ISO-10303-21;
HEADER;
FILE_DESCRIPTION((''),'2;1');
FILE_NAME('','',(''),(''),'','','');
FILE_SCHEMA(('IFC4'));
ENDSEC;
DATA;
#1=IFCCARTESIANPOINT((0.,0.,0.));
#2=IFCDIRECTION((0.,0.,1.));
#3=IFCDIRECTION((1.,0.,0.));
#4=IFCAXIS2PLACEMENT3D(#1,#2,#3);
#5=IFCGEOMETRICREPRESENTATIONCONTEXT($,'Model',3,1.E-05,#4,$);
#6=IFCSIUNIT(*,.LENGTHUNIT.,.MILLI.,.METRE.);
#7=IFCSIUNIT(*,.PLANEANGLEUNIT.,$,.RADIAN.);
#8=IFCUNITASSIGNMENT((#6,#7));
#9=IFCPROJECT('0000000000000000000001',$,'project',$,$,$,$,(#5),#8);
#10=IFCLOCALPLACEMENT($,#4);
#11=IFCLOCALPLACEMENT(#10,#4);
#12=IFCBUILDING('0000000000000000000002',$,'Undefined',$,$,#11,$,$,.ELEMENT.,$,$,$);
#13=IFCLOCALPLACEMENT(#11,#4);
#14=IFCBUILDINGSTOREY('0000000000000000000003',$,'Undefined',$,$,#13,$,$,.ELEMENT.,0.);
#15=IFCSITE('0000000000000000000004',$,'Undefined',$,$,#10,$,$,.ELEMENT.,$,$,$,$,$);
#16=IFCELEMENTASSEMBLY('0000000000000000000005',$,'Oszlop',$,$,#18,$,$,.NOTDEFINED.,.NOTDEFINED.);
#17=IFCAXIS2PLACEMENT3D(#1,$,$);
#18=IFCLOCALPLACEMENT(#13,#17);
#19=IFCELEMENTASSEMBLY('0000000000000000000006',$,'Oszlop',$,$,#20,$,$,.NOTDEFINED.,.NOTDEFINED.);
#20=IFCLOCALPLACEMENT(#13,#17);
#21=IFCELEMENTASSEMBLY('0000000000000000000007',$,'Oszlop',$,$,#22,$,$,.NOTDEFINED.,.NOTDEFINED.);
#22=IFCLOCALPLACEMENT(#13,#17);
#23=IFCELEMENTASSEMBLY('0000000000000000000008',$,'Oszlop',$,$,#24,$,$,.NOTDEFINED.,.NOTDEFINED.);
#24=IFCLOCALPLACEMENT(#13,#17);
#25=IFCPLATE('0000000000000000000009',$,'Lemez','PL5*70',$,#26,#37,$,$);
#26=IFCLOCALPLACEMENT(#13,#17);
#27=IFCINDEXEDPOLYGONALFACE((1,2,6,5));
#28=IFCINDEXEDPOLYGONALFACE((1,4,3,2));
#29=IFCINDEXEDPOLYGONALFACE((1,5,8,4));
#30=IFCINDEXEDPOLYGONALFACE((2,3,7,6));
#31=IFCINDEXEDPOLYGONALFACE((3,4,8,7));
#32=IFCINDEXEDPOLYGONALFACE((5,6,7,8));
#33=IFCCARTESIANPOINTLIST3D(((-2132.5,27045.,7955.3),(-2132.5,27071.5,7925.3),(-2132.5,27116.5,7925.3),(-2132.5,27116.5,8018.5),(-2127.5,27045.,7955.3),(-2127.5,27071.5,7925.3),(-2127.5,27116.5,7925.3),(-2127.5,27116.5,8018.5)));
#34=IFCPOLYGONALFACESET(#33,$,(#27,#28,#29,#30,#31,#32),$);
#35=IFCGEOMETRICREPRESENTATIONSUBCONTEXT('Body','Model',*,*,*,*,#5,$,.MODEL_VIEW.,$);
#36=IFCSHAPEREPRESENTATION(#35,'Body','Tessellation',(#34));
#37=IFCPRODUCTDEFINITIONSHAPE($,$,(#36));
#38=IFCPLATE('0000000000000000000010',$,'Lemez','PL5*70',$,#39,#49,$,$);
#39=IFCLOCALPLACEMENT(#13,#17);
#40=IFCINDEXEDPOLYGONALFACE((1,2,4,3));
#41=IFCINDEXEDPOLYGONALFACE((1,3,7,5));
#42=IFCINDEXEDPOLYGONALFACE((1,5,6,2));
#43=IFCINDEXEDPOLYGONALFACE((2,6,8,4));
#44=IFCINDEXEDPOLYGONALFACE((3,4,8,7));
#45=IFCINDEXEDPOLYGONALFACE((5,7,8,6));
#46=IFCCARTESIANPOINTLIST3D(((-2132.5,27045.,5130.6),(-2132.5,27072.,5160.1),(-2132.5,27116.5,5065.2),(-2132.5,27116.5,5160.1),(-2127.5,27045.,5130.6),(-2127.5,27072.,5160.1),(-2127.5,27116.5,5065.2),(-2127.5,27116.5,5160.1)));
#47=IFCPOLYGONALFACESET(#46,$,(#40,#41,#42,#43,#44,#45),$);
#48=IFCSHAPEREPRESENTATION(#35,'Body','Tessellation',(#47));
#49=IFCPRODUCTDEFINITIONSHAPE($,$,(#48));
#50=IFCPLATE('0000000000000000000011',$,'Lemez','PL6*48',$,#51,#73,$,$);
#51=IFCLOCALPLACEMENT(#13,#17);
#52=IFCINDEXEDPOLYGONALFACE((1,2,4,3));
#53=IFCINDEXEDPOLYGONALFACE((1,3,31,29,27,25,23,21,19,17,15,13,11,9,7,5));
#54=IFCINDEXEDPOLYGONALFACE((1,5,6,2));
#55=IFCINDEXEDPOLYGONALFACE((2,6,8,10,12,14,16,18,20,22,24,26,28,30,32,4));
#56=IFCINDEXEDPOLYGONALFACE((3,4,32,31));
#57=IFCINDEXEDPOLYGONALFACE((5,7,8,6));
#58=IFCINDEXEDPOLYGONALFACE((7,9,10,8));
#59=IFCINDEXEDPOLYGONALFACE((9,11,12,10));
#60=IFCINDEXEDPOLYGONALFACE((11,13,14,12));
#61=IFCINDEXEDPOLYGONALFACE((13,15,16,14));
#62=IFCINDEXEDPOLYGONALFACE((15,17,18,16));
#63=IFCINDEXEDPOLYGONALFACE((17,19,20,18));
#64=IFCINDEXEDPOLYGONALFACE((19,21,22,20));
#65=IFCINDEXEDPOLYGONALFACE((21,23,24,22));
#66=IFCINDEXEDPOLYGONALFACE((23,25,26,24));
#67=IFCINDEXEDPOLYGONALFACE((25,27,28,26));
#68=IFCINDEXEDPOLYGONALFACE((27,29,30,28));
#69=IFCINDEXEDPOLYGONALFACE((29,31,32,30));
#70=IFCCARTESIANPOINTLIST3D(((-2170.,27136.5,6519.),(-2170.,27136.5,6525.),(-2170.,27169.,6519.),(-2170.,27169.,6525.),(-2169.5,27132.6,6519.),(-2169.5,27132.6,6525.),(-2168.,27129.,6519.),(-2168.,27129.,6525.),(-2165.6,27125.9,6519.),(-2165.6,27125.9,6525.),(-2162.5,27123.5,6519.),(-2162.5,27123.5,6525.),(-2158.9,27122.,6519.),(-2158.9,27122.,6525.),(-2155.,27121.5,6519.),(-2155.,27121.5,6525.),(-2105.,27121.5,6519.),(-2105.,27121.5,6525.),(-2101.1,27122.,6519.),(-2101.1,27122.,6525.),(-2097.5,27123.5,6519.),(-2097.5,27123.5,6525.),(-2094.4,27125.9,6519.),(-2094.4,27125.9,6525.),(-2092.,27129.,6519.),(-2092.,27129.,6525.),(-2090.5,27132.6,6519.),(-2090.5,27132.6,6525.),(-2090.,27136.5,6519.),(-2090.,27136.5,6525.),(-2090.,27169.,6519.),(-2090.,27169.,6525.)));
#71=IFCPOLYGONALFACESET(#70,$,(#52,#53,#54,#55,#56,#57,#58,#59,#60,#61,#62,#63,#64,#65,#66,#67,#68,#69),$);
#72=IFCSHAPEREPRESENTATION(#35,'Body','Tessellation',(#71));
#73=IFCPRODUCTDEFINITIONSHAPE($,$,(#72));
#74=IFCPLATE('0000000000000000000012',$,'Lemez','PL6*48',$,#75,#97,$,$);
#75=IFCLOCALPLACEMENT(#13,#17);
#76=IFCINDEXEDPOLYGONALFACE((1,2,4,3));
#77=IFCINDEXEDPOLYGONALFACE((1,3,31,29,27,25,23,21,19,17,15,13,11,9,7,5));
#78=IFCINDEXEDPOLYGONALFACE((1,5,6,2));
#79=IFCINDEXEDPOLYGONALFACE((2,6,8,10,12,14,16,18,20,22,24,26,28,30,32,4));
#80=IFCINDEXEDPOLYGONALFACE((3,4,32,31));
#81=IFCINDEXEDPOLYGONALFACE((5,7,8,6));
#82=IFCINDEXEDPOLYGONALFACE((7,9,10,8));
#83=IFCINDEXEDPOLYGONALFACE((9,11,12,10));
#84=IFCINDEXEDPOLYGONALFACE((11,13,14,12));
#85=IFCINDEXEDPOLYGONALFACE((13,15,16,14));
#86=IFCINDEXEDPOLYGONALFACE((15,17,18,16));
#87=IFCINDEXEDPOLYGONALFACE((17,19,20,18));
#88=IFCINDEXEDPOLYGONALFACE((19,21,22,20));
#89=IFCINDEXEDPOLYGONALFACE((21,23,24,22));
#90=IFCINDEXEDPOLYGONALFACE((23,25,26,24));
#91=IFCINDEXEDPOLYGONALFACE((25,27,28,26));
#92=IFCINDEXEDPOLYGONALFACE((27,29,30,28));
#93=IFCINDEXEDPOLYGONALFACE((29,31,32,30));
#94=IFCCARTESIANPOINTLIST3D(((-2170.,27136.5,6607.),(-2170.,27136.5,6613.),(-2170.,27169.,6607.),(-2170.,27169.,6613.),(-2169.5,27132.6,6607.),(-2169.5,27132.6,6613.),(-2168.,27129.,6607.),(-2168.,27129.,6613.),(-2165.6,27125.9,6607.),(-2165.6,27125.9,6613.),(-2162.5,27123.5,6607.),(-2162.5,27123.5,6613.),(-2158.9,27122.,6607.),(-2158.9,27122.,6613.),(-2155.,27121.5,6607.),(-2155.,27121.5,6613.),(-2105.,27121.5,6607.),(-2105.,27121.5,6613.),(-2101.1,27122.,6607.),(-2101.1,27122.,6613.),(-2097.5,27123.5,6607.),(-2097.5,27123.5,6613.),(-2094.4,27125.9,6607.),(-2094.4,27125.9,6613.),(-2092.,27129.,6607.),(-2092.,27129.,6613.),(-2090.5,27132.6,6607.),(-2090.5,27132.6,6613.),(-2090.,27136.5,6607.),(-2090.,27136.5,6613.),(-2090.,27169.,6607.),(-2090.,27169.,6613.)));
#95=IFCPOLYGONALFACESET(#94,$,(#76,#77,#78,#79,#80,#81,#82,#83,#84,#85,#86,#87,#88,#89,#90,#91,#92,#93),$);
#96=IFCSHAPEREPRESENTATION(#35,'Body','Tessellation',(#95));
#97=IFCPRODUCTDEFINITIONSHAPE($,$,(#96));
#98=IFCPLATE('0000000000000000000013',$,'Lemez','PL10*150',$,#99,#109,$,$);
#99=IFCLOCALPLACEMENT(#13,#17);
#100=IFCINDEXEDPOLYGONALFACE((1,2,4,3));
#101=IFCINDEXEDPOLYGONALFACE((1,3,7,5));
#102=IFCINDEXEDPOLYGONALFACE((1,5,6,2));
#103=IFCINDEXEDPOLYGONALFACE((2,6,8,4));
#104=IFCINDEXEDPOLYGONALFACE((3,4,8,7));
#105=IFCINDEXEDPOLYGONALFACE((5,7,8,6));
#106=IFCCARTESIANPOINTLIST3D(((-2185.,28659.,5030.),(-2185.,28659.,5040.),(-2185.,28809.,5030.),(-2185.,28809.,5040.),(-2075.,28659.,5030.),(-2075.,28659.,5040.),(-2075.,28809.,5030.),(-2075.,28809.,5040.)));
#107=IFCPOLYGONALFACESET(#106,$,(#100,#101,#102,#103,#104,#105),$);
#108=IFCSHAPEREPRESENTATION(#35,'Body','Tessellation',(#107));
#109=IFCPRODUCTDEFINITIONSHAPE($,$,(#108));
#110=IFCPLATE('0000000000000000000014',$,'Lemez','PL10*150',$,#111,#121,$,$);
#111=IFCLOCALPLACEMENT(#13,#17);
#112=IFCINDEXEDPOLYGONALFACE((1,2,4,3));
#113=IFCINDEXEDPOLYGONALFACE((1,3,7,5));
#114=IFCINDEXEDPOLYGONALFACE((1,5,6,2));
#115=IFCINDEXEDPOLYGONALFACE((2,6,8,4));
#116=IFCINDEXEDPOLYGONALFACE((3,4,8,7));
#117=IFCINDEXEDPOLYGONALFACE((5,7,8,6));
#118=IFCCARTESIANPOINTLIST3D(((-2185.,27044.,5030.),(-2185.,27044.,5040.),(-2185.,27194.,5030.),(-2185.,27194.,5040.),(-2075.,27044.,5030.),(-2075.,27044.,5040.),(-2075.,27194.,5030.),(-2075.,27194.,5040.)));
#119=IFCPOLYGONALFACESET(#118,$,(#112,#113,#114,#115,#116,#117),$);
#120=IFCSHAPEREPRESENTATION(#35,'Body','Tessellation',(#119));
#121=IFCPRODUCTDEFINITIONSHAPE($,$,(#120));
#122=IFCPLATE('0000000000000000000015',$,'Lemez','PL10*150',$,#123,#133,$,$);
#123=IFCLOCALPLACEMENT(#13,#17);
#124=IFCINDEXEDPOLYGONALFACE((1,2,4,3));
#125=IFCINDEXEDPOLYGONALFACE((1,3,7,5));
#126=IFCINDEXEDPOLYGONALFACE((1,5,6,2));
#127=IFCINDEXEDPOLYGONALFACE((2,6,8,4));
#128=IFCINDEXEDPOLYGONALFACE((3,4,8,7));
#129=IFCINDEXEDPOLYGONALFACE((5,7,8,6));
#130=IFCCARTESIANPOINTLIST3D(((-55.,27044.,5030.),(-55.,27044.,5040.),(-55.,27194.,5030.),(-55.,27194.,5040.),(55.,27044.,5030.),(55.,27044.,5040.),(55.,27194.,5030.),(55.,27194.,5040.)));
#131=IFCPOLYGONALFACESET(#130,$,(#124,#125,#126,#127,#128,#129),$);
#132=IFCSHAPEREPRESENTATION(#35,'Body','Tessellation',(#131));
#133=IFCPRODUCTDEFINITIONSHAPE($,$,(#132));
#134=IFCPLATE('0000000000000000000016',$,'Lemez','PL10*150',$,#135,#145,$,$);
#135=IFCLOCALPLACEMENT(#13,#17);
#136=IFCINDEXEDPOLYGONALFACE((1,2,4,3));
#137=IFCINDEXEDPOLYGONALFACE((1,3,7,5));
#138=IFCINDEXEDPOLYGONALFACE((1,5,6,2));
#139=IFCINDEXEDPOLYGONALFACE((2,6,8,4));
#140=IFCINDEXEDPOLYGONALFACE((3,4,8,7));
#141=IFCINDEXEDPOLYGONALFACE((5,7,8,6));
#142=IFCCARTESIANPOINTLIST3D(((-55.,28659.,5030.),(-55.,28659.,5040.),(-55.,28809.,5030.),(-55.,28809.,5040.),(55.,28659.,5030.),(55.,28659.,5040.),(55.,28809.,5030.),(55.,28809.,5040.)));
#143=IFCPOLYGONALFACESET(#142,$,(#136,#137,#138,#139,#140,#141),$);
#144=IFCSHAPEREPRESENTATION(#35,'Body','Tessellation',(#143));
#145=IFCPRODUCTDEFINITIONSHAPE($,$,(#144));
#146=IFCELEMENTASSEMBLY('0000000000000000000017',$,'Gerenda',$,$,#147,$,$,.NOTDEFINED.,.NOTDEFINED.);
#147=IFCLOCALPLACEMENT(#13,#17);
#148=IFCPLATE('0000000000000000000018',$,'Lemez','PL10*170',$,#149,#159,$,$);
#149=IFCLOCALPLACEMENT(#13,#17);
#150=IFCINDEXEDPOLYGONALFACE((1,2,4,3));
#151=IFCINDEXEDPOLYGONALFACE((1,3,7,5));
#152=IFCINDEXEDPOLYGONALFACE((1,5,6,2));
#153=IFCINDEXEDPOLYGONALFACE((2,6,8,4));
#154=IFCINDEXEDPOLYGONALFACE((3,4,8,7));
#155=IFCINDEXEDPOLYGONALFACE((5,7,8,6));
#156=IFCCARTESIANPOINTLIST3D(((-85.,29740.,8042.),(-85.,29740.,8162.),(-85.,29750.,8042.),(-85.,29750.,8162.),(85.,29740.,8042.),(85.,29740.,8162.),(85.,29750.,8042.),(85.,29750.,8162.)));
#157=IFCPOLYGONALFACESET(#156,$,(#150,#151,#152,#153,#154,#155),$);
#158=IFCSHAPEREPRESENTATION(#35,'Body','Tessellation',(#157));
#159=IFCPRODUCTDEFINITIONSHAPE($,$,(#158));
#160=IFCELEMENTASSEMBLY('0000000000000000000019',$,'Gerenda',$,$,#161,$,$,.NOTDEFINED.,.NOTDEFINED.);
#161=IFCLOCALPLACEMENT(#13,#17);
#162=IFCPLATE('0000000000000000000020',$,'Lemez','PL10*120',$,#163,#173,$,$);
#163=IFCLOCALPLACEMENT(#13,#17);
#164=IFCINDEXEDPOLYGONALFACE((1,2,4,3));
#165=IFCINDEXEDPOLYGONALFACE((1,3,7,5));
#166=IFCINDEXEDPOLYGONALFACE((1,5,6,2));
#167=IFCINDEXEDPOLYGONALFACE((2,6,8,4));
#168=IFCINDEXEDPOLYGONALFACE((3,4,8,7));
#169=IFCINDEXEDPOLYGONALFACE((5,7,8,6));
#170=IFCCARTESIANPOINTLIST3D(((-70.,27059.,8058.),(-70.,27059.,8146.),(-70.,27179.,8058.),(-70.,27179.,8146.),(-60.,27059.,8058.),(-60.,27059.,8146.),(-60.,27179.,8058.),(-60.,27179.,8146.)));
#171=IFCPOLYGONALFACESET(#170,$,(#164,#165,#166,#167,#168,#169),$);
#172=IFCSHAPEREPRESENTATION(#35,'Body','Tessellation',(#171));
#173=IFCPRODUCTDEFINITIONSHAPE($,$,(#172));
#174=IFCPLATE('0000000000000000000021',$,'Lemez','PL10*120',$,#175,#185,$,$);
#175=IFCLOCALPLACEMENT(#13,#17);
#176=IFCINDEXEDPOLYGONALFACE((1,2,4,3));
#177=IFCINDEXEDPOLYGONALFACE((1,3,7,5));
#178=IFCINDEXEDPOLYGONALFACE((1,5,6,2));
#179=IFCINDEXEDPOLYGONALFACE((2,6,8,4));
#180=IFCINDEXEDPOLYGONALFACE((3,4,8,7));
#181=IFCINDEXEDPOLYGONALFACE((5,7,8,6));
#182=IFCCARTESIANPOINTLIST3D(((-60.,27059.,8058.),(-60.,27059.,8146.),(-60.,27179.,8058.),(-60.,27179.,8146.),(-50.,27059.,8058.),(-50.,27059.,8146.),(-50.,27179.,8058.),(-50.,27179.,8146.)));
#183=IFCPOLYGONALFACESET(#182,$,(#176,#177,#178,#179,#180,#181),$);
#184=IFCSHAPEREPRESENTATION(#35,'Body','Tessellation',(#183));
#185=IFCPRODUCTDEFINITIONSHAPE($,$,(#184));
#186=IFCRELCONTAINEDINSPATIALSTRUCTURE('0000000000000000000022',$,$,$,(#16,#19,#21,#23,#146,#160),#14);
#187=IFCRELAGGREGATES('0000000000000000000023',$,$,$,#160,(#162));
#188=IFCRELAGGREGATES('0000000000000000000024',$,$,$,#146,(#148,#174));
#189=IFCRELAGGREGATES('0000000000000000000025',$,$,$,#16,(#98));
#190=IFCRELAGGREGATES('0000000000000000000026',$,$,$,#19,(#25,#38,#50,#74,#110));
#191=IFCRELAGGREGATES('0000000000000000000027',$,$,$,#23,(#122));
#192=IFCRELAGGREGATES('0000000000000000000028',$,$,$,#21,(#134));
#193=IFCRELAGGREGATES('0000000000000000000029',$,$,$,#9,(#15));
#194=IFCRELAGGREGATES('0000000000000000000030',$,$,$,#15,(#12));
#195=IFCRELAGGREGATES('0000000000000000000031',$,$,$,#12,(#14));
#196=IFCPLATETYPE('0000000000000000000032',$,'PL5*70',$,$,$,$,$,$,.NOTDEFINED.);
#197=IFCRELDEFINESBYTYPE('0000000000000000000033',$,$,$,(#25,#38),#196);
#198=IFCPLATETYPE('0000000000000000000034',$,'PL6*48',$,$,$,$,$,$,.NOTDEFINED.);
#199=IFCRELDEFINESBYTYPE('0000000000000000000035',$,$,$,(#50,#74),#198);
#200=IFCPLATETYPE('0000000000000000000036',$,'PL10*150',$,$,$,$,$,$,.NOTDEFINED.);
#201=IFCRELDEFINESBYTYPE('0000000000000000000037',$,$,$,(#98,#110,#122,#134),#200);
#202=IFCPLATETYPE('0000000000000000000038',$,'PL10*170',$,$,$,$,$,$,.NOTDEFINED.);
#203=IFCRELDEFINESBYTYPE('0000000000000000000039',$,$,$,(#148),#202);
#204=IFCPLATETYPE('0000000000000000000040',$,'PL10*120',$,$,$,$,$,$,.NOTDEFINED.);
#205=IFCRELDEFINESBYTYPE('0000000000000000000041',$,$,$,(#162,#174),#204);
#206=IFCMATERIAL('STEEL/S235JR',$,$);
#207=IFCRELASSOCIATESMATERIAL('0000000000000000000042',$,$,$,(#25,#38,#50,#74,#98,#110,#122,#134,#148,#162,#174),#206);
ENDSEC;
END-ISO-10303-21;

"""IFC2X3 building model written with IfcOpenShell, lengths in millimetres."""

from ifc_helpers import new_model, si_unit, frame, frame_2d, origin_with_axes, place, context, subcontext, project, spatial, polyline, circle_curve, parameter, trimmed, segment, composite_curve, outline, extrude, material, type_object, element, aggregate, save


model = new_model("IFC2X3")

# Units and contexts
model_context = context("Model", 3, precision=1e-05, world=origin_with_axes())
body_context = subcontext(model_context, "Body", "Model", "MODEL_VIEW")
ifc_project = project(units=[si_unit("LENGTHUNIT", "METRE", prefix="MILLI"), si_unit("PLANEANGLEUNIT", "RADIAN")], contexts=[model_context])

# Site, building, storey
site_placement = place(None, origin_with_axes())
site = spatial("IfcSite", under=ifc_project, at=site_placement, Name="Undefined", CompositionType="ELEMENT")
building_placement = place(site_placement, origin_with_axes())
building = spatial("IfcBuilding", under=site, at=building_placement, Name="Undefined", CompositionType="ELEMENT")
storey_placement = place(building_placement, origin_with_axes())
storey = spatial("IfcBuildingStorey", under=building, at=storey_placement, Name="Undefined", CompositionType="ELEMENT", Elevation=0.0)

# Element assemblies
assembly_1_placement = place(storey_placement, origin_with_axes())
assembly_1 = element("IfcElementAssembly", 1, at=assembly_1_placement, inside=storey, Name="Oszlop", AssemblyPlace="NOTDEFINED", PredefinedType="NOTDEFINED")
ifc_material_1 = material(Name="STEEL/S235JR")
assembly_2_placement = place(storey_placement, origin_with_axes())
assembly_2 = element("IfcElementAssembly", 2, at=assembly_2_placement, inside=storey, Name="Oszlop", AssemblyPlace="NOTDEFINED", PredefinedType="NOTDEFINED")
assembly_3_placement = place(storey_placement, origin_with_axes())
assembly_3 = element("IfcElementAssembly", 3, at=assembly_3_placement, inside=storey, Name="Oszlop", AssemblyPlace="NOTDEFINED", PredefinedType="NOTDEFINED")
assembly_4_placement = place(storey_placement, origin_with_axes())
assembly_4 = element("IfcElementAssembly", 4, at=assembly_4_placement, inside=storey, Name="Oszlop", AssemblyPlace="NOTDEFINED", PredefinedType="NOTDEFINED")

# Plates
plate_type_1 = type_object("IfcPlateType", Name="PL5*70", PredefinedType="NOTDEFINED")
plate_1_placement = place(assembly_2_placement, frame((-2130.0, 27116.5, 7925.3), z_axis=(1.0, -0.000004, 0.0), x_axis=(0.0, 0.0, 1.0)))
plate_1 = element("IfcPlate", 5, at=plate_1_placement, type_object=plate_type_1, material=ifc_material_1, Name="Lemez", Description="PL5*70", context=body_context, shape_type="SweptSolid", body=[
    extrude(outline(polyline([(0.0, 0.0), (93.2, 0.0), (30.0, 71.5), (0.0, 45.0), (0.0, 0.0)])), frame((0.0, 0.0, -2.5), z_axis=(0.0, 0.0, 1.0), x_axis=(1.0, 0.0, 0.0)), (0.0, 0.0, 1.0), 5.0),
])
plate_2_placement = place(assembly_2_placement, frame((-2130.0, 27116.5, 5160.1), z_axis=(-1.0, -0.000005, 0.0), x_axis=(0.0, 0.0, -1.0)))
plate_2 = element("IfcPlate", 6, at=plate_2_placement, type_object=plate_type_1, material=ifc_material_1, Name="Lemez", Description="PL5*70", context=body_context, shape_type="SweptSolid", body=[
    extrude(outline(polyline([(0.0, 0.0), (94.9, 0.0), (29.5, 71.5), (0.0, 44.5), (0.0, 0.0)])), frame((0.0, 0.0, -2.5), z_axis=(0.0, 0.0, 1.0), x_axis=(1.0, 0.0, 0.0)), (0.0, 0.0, 1.0), 5.0),
])
plate_type_2 = type_object("IfcPlateType", Name="PL6*48", PredefinedType="NOTDEFINED")
plate_3_placement = place(assembly_2_placement, frame((-2090.0, 27169.0, 6522.0), z_axis=(0.0, 0.0, -1.0), x_axis=(0.0, -1.0, 0.0)))
plate_3 = element("IfcPlate", 7, at=plate_3_placement, type_object=plate_type_2, material=ifc_material_1, Name="Lemez", Description="PL6*48", context=body_context, shape_type="SweptSolid", body=[
    extrude(outline(composite_curve([segment(polyline([(0.0, 0.0), (32.5, 0.0)]), True, "CONTINUOUS"), segment(trimmed(circle_curve(frame_2d((32.5, 15.0), x_axis=(0.0, -1.0)), 15.0), [parameter(0.0)], [parameter(1.570796)], True, "PARAMETER"), True, "CONTINUOUS"), segment(polyline([(47.5, 15.0), (47.5, 65.0)]), True, "CONTINUOUS"), segment(trimmed(circle_curve(frame_2d((32.5, 65.0), x_axis=(1.0, 0.0)), 15.0), [parameter(0.0)], [parameter(1.570796)], True, "PARAMETER"), True, "CONTINUOUS"), segment(polyline([(32.5, 80.0), (0.0, 80.0), (0.0, 0.0)]), True, "CONTINUOUS")], self_intersect=True)), frame((0.0, 0.0, -3.0), z_axis=(0.0, 0.0, 1.0), x_axis=(1.0, 0.0, 0.0)), (0.0, 0.0, 1.0), 6.0),
])
plate_4_placement = place(assembly_2_placement, frame((-2090.0, 27169.0, 6610.0), z_axis=(0.0, 0.0, 1.0), x_axis=(-1.0, 0.0, 0.0)))
plate_4 = element("IfcPlate", 8, at=plate_4_placement, type_object=plate_type_2, material=ifc_material_1, Name="Lemez", Description="PL6*48", context=body_context, shape_type="SweptSolid", body=[
    extrude(outline(composite_curve([segment(polyline([(0.0, 0.0), (80.0, 0.0), (80.0, 32.5)]), True, "CONTINUOUS"), segment(trimmed(circle_curve(frame_2d((65.0, 32.5), x_axis=(1.0, 0.0)), 15.0), [parameter(0.0)], [parameter(1.570796)], True, "PARAMETER"), True, "CONTINUOUS"), segment(polyline([(65.0, 47.5), (15.0, 47.5)]), True, "CONTINUOUS"), segment(trimmed(circle_curve(frame_2d((15.0, 32.5), x_axis=(0.0, 1.0)), 15.0), [parameter(0.0)], [parameter(1.570796)], True, "PARAMETER"), True, "CONTINUOUS"), segment(polyline([(0.0, 32.5), (0.0, 0.0)]), True, "CONTINUOUS")], self_intersect=True)), frame((0.0, 0.0, -3.0), z_axis=(0.0, 0.0, 1.0), x_axis=(1.0, 0.0, 0.0)), (0.0, 0.0, 1.0), 6.0),
])
plate_type_3 = type_object("IfcPlateType", Name="PL10*150", PredefinedType="NOTDEFINED")
plate_5_placement = place(assembly_1_placement, frame((-2075.0, 28734.0, 5035.0), z_axis=(0.0, 0.0, 1.0), x_axis=(-1.0, 0.0, 0.0)))
plate_5 = element("IfcPlate", 9, at=plate_5_placement, type_object=plate_type_3, material=ifc_material_1, Name="Lemez", Description="PL10*150", context=body_context, shape_type="SweptSolid", body=[
    extrude(outline(polyline([(0.0, -75.0), (0.0, 75.0), (110.0, 75.0), (110.0, -75.0), (0.0, -75.0)])), frame((0.0, 0.0, -5.0), z_axis=(0.0, 0.0, 1.0), x_axis=(1.0, 0.0, 0.0)), (0.0, 0.0, 1.0), 10.0),
])
plate_6_placement = place(assembly_2_placement, frame((-2075.0, 27119.0, 5035.0), z_axis=(0.0, 0.0, 1.0), x_axis=(-1.0, 0.0, 0.0)))
plate_6 = element("IfcPlate", 10, at=plate_6_placement, type_object=plate_type_3, material=ifc_material_1, Name="Lemez", Description="PL10*150", context=body_context, shape_type="SweptSolid", body=[
    extrude(outline(polyline([(0.0, -75.0), (0.0, 75.0), (110.0, 75.0), (110.0, -75.0), (0.0, -75.0)])), frame((0.0, 0.0, -5.0), z_axis=(0.0, 0.0, 1.0), x_axis=(1.0, 0.0, 0.0)), (0.0, 0.0, 1.0), 10.0),
])
plate_7_placement = place(assembly_4_placement, frame((55.0, 27119.0, 5035.0), z_axis=(0.0, 0.0, 1.0), x_axis=(-1.0, 0.0, 0.0)))
plate_7 = element("IfcPlate", 11, at=plate_7_placement, type_object=plate_type_3, material=ifc_material_1, Name="Lemez", Description="PL10*150", context=body_context, shape_type="SweptSolid", body=[
    extrude(outline(polyline([(0.0, -75.0), (0.0, 75.0), (110.0, 75.0), (110.0, -75.0), (0.0, -75.0)])), frame((0.0, 0.0, -5.0), z_axis=(0.0, 0.0, 1.0), x_axis=(1.0, 0.0, 0.0)), (0.0, 0.0, 1.0), 10.0),
])
plate_8_placement = place(assembly_3_placement, frame((55.0, 28734.0, 5035.0), z_axis=(0.0, 0.0, 1.0), x_axis=(-1.0, 0.0, 0.0)))
plate_8 = element("IfcPlate", 12, at=plate_8_placement, type_object=plate_type_3, material=ifc_material_1, Name="Lemez", Description="PL10*150", context=body_context, shape_type="SweptSolid", body=[
    extrude(outline(polyline([(0.0, -75.0), (0.0, 75.0), (110.0, 75.0), (110.0, -75.0), (0.0, -75.0)])), frame((0.0, 0.0, -5.0), z_axis=(0.0, 0.0, 1.0), x_axis=(1.0, 0.0, 0.0)), (0.0, 0.0, 1.0), 10.0),
])

# Element assemblies, plates
assembly_5_placement = place(storey_placement, origin_with_axes())
assembly_5 = element("IfcElementAssembly", 13, at=assembly_5_placement, inside=storey, Name="Gerenda", AssemblyPlace="NOTDEFINED", PredefinedType="NOTDEFINED")
plate_type_4 = type_object("IfcPlateType", Name="PL10*170", PredefinedType="NOTDEFINED")
plate_9_placement = place(assembly_5_placement, frame((0.0, 29745.0, 8042.0), z_axis=(-0.000003, -1.0, 0.0), x_axis=(0.0, 0.0, 1.0)))
plate_9 = element("IfcPlate", 14, at=plate_9_placement, type_object=plate_type_4, material=ifc_material_1, Name="Lemez", Description="PL10*170", context=body_context, shape_type="SweptSolid", body=[
    extrude(outline(polyline([(0.0, -85.0), (0.0, 85.0), (120.0, 85.0), (120.0, -85.0), (0.0, -85.0)])), frame((0.0, 0.0, -5.0), z_axis=(0.0, 0.0, 1.0), x_axis=(1.0, 0.0, 0.0)), (0.0, 0.0, 1.0), 10.0),
])
assembly_6_placement = place(storey_placement, origin_with_axes())
assembly_6 = element("IfcElementAssembly", 15, at=assembly_6_placement, inside=storey, Name="Gerenda", AssemblyPlace="NOTDEFINED", PredefinedType="NOTDEFINED")
plate_type_5 = type_object("IfcPlateType", Name="PL10*120", PredefinedType="NOTDEFINED")
plate_10_placement = place(assembly_6_placement, frame((-65.0, 27119.0, 8058.0), z_axis=(-1.0, 0.000003, 0.0), x_axis=(0.0, 0.0, 1.0)))
plate_10 = element("IfcPlate", 16, at=plate_10_placement, type_object=plate_type_5, material=ifc_material_1, Name="Lemez", Description="PL10*120", context=body_context, shape_type="SweptSolid", body=[
    extrude(outline(polyline([(0.0, -60.0), (0.0, 60.0), (88.0, 60.0), (88.0, -60.0), (0.0, -60.0)])), frame((0.0, 0.0, -5.0), z_axis=(0.0, 0.0, 1.0), x_axis=(1.0, 0.0, 0.0)), (0.0, 0.0, 1.0), 10.0),
])
aggregate(assembly_6, [plate_10])

# Plate
plate_11_placement = place(assembly_5_placement, frame((-55.0, 27119.0, 8058.0), z_axis=(-1.0, 0.000003, 0.0), x_axis=(0.0, 0.0, 1.0)))
plate_11 = element("IfcPlate", 17, at=plate_11_placement, type_object=plate_type_5, material=ifc_material_1, Name="Lemez", Description="PL10*120", context=body_context, shape_type="SweptSolid", body=[
    extrude(outline(polyline([(0.0, -60.0), (0.0, 60.0), (88.0, 60.0), (88.0, -60.0), (0.0, -60.0)])), frame((0.0, 0.0, -5.0), z_axis=(0.0, 0.0, 1.0), x_axis=(1.0, 0.0, 0.0)), (0.0, 0.0, 1.0), 10.0),
])
aggregate(assembly_5, [plate_9, plate_11])

aggregate(assembly_1, [plate_5])
aggregate(assembly_2, [plate_1, plate_2, plate_3, plate_4, plate_6])
aggregate(assembly_4, [plate_7])
aggregate(assembly_3, [plate_8])

save(model, "model.ifc")
